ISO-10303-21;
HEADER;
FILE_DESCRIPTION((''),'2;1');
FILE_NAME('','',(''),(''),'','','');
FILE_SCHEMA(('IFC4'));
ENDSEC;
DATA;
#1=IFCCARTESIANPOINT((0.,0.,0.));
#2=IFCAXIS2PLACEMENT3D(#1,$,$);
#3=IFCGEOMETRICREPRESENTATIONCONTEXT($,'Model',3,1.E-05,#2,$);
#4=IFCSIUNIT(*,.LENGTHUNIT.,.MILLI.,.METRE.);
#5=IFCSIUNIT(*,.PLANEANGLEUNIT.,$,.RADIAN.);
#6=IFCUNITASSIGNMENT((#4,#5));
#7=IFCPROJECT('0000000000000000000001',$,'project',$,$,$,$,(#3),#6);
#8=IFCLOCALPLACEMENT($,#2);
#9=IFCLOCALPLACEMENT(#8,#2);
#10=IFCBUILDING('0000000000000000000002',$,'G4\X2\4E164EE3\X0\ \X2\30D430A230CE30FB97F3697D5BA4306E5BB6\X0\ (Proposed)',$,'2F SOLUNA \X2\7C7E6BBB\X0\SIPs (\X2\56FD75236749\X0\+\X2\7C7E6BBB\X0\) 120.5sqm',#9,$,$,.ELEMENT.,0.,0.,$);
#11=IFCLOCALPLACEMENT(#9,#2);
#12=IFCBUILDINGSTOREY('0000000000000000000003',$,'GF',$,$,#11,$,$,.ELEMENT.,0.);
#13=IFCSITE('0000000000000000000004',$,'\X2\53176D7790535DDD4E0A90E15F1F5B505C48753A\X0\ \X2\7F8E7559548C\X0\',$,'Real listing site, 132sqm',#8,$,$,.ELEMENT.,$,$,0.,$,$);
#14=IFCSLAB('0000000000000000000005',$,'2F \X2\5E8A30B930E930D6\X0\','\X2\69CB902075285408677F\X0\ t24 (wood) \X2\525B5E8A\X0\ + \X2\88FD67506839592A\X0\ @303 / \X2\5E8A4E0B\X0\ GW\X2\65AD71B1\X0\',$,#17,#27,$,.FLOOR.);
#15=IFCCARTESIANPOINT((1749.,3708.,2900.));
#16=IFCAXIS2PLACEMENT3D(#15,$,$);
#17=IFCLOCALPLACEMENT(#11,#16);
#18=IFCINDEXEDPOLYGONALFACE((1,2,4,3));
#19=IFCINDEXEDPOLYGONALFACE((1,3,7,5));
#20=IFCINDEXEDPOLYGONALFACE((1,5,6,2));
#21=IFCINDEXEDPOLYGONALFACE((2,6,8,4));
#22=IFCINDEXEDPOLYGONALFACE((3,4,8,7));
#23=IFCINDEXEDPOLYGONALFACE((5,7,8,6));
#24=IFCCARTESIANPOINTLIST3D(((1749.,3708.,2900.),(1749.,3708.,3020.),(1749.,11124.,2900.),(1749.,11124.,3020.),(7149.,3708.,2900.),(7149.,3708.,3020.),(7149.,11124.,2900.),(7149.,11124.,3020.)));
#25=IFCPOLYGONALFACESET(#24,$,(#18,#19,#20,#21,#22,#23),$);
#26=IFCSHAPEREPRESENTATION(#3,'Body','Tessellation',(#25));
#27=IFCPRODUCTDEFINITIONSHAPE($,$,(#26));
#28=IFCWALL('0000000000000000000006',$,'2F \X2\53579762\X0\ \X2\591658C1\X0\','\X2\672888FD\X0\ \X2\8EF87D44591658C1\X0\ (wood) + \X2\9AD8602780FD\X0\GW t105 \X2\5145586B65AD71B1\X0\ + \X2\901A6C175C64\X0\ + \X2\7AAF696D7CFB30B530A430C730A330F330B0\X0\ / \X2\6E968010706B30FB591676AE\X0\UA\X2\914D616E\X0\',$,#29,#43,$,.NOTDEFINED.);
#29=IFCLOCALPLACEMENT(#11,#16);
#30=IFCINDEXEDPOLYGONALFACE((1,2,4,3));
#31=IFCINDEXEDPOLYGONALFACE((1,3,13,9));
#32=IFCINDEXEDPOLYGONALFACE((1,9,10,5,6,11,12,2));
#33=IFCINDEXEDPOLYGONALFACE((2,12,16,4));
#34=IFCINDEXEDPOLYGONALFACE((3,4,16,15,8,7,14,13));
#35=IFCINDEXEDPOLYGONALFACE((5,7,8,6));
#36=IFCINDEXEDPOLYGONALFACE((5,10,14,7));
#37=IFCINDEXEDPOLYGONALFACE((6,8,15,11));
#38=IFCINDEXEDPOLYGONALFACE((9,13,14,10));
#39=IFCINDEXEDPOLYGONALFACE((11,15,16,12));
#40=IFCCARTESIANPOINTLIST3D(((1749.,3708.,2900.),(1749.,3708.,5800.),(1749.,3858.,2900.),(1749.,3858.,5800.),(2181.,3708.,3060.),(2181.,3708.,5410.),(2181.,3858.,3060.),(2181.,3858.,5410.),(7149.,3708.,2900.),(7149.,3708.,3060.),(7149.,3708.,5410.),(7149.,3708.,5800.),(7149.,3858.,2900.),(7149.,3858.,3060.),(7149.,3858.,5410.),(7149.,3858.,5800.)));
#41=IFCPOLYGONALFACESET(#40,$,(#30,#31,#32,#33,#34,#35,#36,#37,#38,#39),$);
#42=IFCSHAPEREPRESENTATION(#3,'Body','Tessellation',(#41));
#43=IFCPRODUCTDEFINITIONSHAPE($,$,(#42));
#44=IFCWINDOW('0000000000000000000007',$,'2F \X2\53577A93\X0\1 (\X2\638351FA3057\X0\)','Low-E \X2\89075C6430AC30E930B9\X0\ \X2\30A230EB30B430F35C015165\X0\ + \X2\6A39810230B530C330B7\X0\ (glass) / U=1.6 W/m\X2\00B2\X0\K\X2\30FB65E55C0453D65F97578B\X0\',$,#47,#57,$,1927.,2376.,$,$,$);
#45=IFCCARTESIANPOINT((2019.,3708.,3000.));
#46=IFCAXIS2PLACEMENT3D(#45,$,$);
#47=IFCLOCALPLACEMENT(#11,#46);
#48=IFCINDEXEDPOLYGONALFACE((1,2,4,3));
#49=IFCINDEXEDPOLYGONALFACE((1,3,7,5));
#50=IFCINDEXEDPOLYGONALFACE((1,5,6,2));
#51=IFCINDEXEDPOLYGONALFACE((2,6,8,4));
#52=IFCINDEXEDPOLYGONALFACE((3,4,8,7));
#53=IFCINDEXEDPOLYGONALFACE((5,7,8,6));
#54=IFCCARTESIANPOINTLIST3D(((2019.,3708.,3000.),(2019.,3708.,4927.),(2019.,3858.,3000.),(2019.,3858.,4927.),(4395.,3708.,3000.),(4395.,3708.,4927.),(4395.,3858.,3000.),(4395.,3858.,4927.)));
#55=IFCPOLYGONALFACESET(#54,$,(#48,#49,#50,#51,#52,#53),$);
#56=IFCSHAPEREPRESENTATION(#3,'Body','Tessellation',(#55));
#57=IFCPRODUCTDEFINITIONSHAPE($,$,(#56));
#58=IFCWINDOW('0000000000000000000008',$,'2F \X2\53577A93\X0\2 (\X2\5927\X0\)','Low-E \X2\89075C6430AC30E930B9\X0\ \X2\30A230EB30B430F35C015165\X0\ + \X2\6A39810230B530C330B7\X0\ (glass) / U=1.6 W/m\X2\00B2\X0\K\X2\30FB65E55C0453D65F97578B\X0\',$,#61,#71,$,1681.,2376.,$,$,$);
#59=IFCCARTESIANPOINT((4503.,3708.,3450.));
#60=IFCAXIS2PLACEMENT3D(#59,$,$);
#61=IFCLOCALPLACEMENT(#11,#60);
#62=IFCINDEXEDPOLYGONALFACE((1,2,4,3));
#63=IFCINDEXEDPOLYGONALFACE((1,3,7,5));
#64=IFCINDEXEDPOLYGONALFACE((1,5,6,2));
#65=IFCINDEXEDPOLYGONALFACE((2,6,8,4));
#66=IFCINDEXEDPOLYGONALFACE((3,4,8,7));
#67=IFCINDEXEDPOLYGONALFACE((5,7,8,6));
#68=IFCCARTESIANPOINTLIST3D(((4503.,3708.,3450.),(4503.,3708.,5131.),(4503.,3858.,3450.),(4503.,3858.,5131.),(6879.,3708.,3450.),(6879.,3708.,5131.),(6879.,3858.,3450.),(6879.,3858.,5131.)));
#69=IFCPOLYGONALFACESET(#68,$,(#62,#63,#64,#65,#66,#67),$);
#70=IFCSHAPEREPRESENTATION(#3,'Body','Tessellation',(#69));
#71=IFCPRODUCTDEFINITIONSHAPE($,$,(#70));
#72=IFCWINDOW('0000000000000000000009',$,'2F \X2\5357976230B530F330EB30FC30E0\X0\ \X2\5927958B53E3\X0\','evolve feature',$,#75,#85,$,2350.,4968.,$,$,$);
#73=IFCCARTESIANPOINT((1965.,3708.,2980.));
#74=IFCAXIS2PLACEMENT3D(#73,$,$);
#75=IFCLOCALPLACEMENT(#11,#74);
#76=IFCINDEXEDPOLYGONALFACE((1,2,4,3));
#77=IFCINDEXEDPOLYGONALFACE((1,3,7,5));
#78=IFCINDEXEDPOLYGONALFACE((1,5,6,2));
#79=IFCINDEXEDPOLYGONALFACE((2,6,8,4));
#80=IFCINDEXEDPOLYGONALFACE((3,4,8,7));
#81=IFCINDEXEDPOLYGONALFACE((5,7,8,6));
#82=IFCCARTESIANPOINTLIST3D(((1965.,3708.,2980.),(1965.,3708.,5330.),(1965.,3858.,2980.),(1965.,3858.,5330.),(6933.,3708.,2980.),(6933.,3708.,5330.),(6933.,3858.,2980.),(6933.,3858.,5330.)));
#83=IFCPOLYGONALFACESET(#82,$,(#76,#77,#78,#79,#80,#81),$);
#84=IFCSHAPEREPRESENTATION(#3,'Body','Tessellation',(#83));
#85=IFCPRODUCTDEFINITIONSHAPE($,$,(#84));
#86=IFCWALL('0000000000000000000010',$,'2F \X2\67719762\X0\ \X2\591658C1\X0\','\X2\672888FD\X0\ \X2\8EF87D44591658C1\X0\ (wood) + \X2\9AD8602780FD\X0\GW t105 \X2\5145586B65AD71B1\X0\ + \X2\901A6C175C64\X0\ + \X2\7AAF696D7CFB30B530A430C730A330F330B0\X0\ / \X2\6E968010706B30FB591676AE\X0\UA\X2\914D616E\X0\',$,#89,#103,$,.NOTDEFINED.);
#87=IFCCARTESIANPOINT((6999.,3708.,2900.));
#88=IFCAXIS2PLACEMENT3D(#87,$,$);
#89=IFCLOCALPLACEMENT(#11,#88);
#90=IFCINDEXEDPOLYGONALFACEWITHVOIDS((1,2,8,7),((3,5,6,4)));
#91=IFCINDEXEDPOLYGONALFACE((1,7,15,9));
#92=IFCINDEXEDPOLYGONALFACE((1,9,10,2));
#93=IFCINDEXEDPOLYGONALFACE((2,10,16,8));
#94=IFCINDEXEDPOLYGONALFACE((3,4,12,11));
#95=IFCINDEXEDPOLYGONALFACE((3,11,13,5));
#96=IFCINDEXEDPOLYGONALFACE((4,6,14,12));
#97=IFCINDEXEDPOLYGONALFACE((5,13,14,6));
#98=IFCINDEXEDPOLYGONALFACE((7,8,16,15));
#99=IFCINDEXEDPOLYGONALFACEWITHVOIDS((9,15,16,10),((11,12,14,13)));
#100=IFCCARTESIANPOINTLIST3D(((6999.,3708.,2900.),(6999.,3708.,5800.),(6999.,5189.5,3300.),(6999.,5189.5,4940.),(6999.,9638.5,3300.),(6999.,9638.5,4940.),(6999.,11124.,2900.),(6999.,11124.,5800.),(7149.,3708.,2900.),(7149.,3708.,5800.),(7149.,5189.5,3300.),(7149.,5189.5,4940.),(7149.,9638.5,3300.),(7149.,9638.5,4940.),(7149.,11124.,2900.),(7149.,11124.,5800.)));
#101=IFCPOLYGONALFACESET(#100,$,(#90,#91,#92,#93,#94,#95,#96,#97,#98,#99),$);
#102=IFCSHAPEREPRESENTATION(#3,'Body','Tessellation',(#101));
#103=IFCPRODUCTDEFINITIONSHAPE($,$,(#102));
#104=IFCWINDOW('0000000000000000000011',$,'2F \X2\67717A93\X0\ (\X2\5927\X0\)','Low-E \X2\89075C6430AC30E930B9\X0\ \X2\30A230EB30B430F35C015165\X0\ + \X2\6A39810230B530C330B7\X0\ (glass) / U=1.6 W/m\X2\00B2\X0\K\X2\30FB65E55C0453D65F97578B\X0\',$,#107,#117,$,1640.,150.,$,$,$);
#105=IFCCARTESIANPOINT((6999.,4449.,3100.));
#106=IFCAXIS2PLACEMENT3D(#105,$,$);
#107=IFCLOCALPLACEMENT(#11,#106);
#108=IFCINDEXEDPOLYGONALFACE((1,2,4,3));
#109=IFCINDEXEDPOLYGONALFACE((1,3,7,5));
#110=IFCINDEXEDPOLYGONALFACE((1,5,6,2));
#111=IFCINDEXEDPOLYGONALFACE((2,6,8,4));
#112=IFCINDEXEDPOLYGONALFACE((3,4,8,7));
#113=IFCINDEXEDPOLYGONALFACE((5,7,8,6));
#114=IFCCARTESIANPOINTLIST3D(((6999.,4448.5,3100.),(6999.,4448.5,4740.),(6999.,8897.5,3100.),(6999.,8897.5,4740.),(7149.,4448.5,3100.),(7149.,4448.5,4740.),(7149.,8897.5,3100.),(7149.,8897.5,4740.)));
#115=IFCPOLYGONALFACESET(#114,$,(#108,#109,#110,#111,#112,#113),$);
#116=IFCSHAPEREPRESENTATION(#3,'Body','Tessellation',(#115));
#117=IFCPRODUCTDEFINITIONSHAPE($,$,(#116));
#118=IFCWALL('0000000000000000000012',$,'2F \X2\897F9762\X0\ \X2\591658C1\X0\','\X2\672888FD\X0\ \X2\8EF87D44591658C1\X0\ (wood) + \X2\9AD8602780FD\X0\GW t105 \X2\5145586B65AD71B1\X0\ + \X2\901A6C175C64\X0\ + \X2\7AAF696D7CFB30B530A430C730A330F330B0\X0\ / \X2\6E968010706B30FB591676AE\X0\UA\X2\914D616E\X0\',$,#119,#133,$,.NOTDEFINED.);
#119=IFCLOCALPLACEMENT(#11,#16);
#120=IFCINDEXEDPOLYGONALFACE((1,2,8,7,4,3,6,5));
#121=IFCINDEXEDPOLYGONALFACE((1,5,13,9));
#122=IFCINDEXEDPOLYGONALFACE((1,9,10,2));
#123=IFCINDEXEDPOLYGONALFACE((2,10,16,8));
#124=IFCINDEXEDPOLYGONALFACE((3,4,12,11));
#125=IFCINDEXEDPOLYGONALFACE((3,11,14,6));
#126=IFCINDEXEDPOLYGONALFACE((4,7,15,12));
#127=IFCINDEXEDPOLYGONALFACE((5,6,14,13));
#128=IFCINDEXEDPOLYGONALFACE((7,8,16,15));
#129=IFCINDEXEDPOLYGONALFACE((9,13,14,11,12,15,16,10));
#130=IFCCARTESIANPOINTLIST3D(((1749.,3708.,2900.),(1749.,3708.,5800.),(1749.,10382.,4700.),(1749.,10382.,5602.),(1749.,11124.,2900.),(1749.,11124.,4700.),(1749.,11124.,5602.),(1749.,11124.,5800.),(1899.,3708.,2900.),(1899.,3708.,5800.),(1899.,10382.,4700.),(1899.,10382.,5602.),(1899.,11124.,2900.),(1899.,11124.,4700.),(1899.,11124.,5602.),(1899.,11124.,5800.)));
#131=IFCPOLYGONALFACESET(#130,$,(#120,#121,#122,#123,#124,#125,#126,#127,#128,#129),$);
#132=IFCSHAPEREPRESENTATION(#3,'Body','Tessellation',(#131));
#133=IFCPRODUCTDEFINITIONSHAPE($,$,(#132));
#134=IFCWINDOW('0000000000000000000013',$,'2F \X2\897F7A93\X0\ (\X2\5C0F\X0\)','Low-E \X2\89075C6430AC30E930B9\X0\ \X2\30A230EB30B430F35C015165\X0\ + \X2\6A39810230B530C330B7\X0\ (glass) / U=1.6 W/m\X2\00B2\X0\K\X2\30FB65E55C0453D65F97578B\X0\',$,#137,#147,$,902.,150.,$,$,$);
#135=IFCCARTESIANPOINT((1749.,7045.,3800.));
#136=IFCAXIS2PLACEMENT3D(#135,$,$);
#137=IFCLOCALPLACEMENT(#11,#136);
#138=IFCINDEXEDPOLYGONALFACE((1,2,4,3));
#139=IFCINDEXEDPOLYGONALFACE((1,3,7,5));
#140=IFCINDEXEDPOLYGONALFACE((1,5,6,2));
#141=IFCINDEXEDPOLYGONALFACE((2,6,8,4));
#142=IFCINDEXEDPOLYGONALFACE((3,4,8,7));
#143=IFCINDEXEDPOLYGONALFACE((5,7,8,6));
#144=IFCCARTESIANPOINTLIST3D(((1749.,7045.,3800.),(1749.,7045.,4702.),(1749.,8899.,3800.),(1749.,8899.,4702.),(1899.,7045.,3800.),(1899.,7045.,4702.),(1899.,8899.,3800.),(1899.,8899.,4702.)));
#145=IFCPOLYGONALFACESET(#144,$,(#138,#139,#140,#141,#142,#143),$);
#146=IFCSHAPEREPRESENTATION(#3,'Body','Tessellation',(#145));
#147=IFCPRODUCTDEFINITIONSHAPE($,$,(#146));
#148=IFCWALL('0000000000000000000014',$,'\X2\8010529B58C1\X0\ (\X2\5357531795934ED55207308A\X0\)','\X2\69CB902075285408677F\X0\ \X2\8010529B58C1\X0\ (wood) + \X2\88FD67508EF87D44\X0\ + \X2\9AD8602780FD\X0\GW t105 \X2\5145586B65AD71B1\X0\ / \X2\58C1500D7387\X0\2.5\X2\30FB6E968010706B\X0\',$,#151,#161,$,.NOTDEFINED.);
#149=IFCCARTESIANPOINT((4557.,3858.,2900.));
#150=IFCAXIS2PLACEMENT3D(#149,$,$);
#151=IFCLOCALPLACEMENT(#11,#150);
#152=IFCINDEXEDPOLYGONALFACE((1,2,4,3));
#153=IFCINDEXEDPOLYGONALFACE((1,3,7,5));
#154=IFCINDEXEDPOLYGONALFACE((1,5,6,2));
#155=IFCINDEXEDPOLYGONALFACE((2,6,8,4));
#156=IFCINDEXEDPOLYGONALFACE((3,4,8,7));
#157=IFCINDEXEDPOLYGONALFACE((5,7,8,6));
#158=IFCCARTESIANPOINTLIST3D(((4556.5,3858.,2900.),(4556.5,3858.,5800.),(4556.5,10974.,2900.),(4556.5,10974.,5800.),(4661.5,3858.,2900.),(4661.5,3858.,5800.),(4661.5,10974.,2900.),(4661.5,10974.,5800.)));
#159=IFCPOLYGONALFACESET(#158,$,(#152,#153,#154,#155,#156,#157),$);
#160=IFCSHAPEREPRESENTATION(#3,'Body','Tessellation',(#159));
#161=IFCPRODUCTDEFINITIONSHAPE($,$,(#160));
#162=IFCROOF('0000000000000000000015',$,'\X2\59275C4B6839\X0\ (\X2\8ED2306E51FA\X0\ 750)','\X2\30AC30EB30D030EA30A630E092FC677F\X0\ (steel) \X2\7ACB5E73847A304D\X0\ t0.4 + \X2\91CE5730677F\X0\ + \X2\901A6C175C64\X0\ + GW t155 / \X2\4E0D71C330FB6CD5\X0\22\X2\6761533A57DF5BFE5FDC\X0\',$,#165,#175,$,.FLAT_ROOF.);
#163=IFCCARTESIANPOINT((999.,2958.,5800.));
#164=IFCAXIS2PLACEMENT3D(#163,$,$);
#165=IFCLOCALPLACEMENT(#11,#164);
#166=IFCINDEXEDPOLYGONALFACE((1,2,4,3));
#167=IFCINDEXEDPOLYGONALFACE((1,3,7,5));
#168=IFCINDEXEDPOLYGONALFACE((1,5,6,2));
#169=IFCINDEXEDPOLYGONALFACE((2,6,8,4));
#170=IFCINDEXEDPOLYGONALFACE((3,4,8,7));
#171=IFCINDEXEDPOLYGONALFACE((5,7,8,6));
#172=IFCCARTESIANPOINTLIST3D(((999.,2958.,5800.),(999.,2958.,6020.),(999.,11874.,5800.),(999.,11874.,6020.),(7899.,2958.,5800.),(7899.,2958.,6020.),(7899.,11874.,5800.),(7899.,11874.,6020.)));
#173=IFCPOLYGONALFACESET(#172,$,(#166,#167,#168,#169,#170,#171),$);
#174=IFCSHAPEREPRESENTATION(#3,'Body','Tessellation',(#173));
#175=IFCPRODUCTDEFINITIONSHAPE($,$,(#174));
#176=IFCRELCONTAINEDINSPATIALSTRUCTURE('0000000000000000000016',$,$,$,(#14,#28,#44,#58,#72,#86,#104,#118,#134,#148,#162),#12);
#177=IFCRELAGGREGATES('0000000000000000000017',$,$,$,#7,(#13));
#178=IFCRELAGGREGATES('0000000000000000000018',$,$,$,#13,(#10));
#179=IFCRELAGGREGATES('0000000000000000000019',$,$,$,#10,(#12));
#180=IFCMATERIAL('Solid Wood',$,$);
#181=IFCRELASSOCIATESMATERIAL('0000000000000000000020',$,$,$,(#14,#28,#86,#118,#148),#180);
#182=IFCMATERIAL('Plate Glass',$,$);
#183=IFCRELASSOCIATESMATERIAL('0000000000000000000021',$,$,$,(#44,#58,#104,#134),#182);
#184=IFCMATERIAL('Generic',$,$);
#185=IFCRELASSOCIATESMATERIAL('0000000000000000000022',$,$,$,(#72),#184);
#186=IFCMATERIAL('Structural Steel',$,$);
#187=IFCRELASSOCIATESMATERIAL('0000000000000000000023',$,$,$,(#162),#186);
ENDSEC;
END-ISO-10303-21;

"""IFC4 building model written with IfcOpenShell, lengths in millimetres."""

from ifc_helpers import new_model, si_unit, frame, frame_2d, origin, place, context, project, spatial, rectangle, extrude, material, element, fill, save


model = new_model("IFC4")

# Units and contexts
model_context = context("Model", 3, precision=1e-05, world=origin())
ifc_project = project(units=[si_unit("LENGTHUNIT", "METRE", prefix="MILLI"), si_unit("PLANEANGLEUNIT", "RADIAN")], contexts=[model_context])

# Site, building, storey
site_placement = place(None, origin())
site = spatial("IfcSite", under=ifc_project, at=site_placement, Name="北海道川上郡弟子屈町 美留和", ObjectType="Real listing site, 132sqm", CompositionType="ELEMENT", RefElevation=0.0)
building_placement = place(site_placement, origin())
building = spatial("IfcBuilding", under=site, at=building_placement, Name="G4世代 ピアノ・音楽室の家 (Proposed)", ObjectType="2F SOLUNA 籾殻SIPs (国産杉+籾殻) 120.5sqm", CompositionType="ELEMENT", ElevationOfRefHeight=0.0, ElevationOfTerrain=0.0)
storey_placement = place(building_placement, origin())
storey = spatial("IfcBuildingStorey", under=building, at=storey_placement, Name="GF", CompositionType="ELEMENT", Elevation=0.0)

# Slab
ifc_material_1 = material(Name="Solid Wood")
slab_placement = place(storey_placement, frame((1749.0, 3708.0, 2900.0)))
element("IfcSlab", 1, at=slab_placement, inside=storey, material=ifc_material_1, Name="2F 床スラブ", Description="構造用合板 t24 (wood) 剛床 + 製材根太 @303 / 床下 GW断熱", PredefinedType="FLOOR", context=model_context, shape_type="SweptSolid", body=[
    extrude(rectangle(XDim=5400.0, YDim=7416.0, at=frame_2d((2700.0, 3708.0))), frame((1749.0, 3708.0, 2900.0)), (0.0, 0.0, 1.0), 120.0),
])

# Wall, openings, windows
wall_1_placement = place(storey_placement, frame((1749.0, 3708.0, 2900.0)))
wall_1 = element("IfcWall", 2, at=wall_1_placement, inside=storey, material=ifc_material_1, Name="2F 南面 外壁", Description="木製 軸組外壁 (wood) + 高性能GW t105 充填断熱 + 通気層 + 窯業系サイディング / 準耐火・外皮UA配慮", PredefinedType="NOTDEFINED", context=model_context, shape_type="SweptSolid", body=[
    extrude(rectangle(XDim=5400.0, YDim=150.0, at=frame_2d((2700.0, 75.0))), frame((1749.0, 3708.0, 2900.0)), (0.0, 0.0, 1.0), 2900.0),
])
opening_1_placement = place(storey_placement, frame((2019.0, 3708.0, 3000.0)))
opening_1 = element("IfcOpeningElement", 3, at=opening_1_placement, cuts=wall_1, PredefinedType="NOTDEFINED", context=model_context, shape_type="SweptSolid", body=[
    extrude(rectangle(XDim=2376.0, YDim=150.0, at=frame_2d((1188.0, 75.0))), frame((2019.0, 3708.0, 3000.0)), (0.0, 0.0, 1.0), 1927.0),
])
opening_2_placement = place(storey_placement, frame((4503.0, 3708.0, 3450.0)))
opening_2 = element("IfcOpeningElement", 4, at=opening_2_placement, cuts=wall_1, PredefinedType="NOTDEFINED", context=model_context, shape_type="SweptSolid", body=[
    extrude(rectangle(XDim=2376.0, YDim=150.0, at=frame_2d((1188.0, 75.0))), frame((4503.0, 3708.0, 3450.0)), (0.0, 0.0, 1.0), 1681.0),
])
opening_3_placement = place(storey_placement, frame((1965.0, 3708.0, 2980.0)))
opening_3 = element("IfcOpeningElement", 5, at=opening_3_placement, cuts=wall_1, PredefinedType="NOTDEFINED", context=model_context, shape_type="SweptSolid", body=[
    extrude(rectangle(XDim=4968.0, YDim=150.0, at=frame_2d((2484.0, 75.0))), frame((1965.0, 3708.0, 2980.0)), (0.0, 0.0, 1.0), 2350.0),
])
ifc_material_2 = material(Name="Plate Glass")
window_1_placement = place(storey_placement, frame((2019.0, 3708.0, 3000.0)))
window_1 = element("IfcWindow", 6, at=window_1_placement, inside=storey, material=ifc_material_2, Name="2F 南窓1 (掃出し)", Description="Low-E 複層ガラス アルゴン封入 + 樹脂サッシ (glass) / U=1.6 W/m²K・日射取得型", OverallHeight=1927.0, OverallWidth=2376.0, context=model_context, shape_type="SweptSolid", body=[
    extrude(rectangle(XDim=2376.0, YDim=150.0, at=frame_2d((1188.0, 75.0))), frame((2019.0, 3708.0, 3000.0)), (0.0, 0.0, 1.0), 1927.0),
])
fill(opening_1, window_1)
window_2_placement = place(storey_placement, frame((4503.0, 3708.0, 3450.0)))
window_2 = element("IfcWindow", 7, at=window_2_placement, inside=storey, material=ifc_material_2, Name="2F 南窓2 (大)", Description="Low-E 複層ガラス アルゴン封入 + 樹脂サッシ (glass) / U=1.6 W/m²K・日射取得型", OverallHeight=1681.0, OverallWidth=2376.0, context=model_context, shape_type="SweptSolid", body=[
    extrude(rectangle(XDim=2376.0, YDim=150.0, at=frame_2d((1188.0, 75.0))), frame((4503.0, 3708.0, 3450.0)), (0.0, 0.0, 1.0), 1681.0),
])
fill(opening_2, window_2)
ifc_material_3 = material(Name="Generic")
window_3_placement = place(storey_placement, frame((1965.0, 3708.0, 2980.0)))
window_3 = element("IfcWindow", 8, at=window_3_placement, inside=storey, material=ifc_material_3, Name="2F 南面サンルーム 大開口", Description="evolve feature", OverallHeight=2350.0, OverallWidth=4968.0, context=model_context, shape_type="SweptSolid", body=[
    extrude(rectangle(XDim=4968.0, YDim=150.0, at=frame_2d((2484.0, 75.0))), frame((1965.0, 3708.0, 2980.0)), (0.0, 0.0, 1.0), 2350.0),
])
fill(opening_3, window_3)

# Walls, openings, windows
wall_2_placement = place(storey_placement, frame((6999.0, 3708.0, 2900.0)))
wall_2 = element("IfcWall", 9, at=wall_2_placement, inside=storey, material=ifc_material_1, Name="2F 東面 外壁", Description="木製 軸組外壁 (wood) + 高性能GW t105 充填断熱 + 通気層 + 窯業系サイディング / 準耐火・外皮UA配慮", PredefinedType="NOTDEFINED", context=model_context, shape_type="SweptSolid", body=[
    extrude(rectangle(XDim=150.0, YDim=7416.0, at=frame_2d((75.0, 3708.0))), frame((6999.0, 3708.0, 2900.0)), (0.0, 0.0, 1.0), 2900.0),
])
opening_4_placement = place(storey_placement, frame((6999.0, 4449.0, 3100.0)))
opening_4 = element("IfcOpeningElement", 10, at=opening_4_placement, cuts=wall_2, PredefinedType="NOTDEFINED", context=model_context, shape_type="SweptSolid", body=[
    extrude(rectangle(XDim=150.0, YDim=4449.0, at=frame_2d((75.0, 2224.0))), frame((6999.0, 4449.0, 3100.0)), (0.0, 0.0, 1.0), 1640.0),
])
window_4_placement = place(storey_placement, frame((6999.0, 4449.0, 3100.0)))
window_4 = element("IfcWindow", 11, at=window_4_placement, inside=storey, material=ifc_material_2, Name="2F 東窓 (大)", Description="Low-E 複層ガラス アルゴン封入 + 樹脂サッシ (glass) / U=1.6 W/m²K・日射取得型", OverallHeight=1640.0, OverallWidth=150.0, context=model_context, shape_type="SweptSolid", body=[
    extrude(rectangle(XDim=150.0, YDim=4449.0, at=frame_2d((75.0, 2224.0))), frame((6999.0, 4449.0, 3100.0)), (0.0, 0.0, 1.0), 1640.0),
])
fill(opening_4, window_4)
wall_3_placement = place(storey_placement, frame((1749.0, 3708.0, 2900.0)))
wall_3 = element("IfcWall", 12, at=wall_3_placement, inside=storey, material=ifc_material_1, Name="2F 西面 外壁", Description="木製 軸組外壁 (wood) + 高性能GW t105 充填断熱 + 通気層 + 窯業系サイディング / 準耐火・外皮UA配慮", PredefinedType="NOTDEFINED", context=model_context, shape_type="SweptSolid", body=[
    extrude(rectangle(XDim=150.0, YDim=7416.0, at=frame_2d((75.0, 3708.0))), frame((1749.0, 3708.0, 2900.0)), (0.0, 0.0, 1.0), 2900.0),
])
opening_5_placement = place(storey_placement, frame((1749.0, 7045.0, 3800.0)))
opening_5 = element("IfcOpeningElement", 13, at=opening_5_placement, cuts=wall_3, PredefinedType="NOTDEFINED", context=model_context, shape_type="SweptSolid", body=[
    extrude(rectangle(XDim=150.0, YDim=1854.0, at=frame_2d((75.0, 927.0))), frame((1749.0, 7045.0, 3800.0)), (0.0, 0.0, 1.0), 902.0),
])
window_5_placement = place(storey_placement, frame((1749.0, 7045.0, 3800.0)))
window_5 = element("IfcWindow", 14, at=window_5_placement, inside=storey, material=ifc_material_2, Name="2F 西窓 (小)", Description="Low-E 複層ガラス アルゴン封入 + 樹脂サッシ (glass) / U=1.6 W/m²K・日射取得型", OverallHeight=902.0, OverallWidth=150.0, context=model_context, shape_type="SweptSolid", body=[
    extrude(rectangle(XDim=150.0, YDim=1854.0, at=frame_2d((75.0, 927.0))), frame((1749.0, 7045.0, 3800.0)), (0.0, 0.0, 1.0), 902.0),
])
fill(opening_5, window_5)

# Wall
wall_4_placement = place(storey_placement, frame((4557.0, 3858.0, 2900.0)))
element("IfcWall", 15, at=wall_4_placement, inside=storey, material=ifc_material_1, Name="耐力壁 (南北間仕切り)", Description="構造用合板 耐力壁 (wood) + 製材軸組 + 高性能GW t105 充填断熱 / 壁倍率2.5・準耐火", PredefinedType="NOTDEFINED", context=model_context, shape_type="SweptSolid", body=[
    extrude(rectangle(XDim=105.0, YDim=7116.0, at=frame_2d((52.0, 3558.0))), frame((4557.0, 3858.0, 2900.0)), (0.0, 0.0, 1.0), 2900.0),
])

# Roof
ifc_material_4 = material(Name="Structural Steel")
roof_1_placement = place(storey_placement, frame((999.0, 2958.0, 5800.0)))
element("IfcRoof", 16, at=roof_1_placement, inside=storey, material=ifc_material_4, Name="大屋根 (軒の出 750)", Description="ガルバリウム鋼板 (steel) 立平葺き t0.4 + 野地板 + 通気層 + GW t155 / 不燃・法22条区域対応", PredefinedType="FLAT_ROOF", context=model_context, shape_type="SweptSolid", body=[
    extrude(rectangle(XDim=6900.0, YDim=8916.0, at=frame_2d((3450.0, 4458.0))), frame((999.0, 2958.0, 5800.0)), (0.0, 0.0, 1.0), 220.0),
])

save(model, "model.ifc")
